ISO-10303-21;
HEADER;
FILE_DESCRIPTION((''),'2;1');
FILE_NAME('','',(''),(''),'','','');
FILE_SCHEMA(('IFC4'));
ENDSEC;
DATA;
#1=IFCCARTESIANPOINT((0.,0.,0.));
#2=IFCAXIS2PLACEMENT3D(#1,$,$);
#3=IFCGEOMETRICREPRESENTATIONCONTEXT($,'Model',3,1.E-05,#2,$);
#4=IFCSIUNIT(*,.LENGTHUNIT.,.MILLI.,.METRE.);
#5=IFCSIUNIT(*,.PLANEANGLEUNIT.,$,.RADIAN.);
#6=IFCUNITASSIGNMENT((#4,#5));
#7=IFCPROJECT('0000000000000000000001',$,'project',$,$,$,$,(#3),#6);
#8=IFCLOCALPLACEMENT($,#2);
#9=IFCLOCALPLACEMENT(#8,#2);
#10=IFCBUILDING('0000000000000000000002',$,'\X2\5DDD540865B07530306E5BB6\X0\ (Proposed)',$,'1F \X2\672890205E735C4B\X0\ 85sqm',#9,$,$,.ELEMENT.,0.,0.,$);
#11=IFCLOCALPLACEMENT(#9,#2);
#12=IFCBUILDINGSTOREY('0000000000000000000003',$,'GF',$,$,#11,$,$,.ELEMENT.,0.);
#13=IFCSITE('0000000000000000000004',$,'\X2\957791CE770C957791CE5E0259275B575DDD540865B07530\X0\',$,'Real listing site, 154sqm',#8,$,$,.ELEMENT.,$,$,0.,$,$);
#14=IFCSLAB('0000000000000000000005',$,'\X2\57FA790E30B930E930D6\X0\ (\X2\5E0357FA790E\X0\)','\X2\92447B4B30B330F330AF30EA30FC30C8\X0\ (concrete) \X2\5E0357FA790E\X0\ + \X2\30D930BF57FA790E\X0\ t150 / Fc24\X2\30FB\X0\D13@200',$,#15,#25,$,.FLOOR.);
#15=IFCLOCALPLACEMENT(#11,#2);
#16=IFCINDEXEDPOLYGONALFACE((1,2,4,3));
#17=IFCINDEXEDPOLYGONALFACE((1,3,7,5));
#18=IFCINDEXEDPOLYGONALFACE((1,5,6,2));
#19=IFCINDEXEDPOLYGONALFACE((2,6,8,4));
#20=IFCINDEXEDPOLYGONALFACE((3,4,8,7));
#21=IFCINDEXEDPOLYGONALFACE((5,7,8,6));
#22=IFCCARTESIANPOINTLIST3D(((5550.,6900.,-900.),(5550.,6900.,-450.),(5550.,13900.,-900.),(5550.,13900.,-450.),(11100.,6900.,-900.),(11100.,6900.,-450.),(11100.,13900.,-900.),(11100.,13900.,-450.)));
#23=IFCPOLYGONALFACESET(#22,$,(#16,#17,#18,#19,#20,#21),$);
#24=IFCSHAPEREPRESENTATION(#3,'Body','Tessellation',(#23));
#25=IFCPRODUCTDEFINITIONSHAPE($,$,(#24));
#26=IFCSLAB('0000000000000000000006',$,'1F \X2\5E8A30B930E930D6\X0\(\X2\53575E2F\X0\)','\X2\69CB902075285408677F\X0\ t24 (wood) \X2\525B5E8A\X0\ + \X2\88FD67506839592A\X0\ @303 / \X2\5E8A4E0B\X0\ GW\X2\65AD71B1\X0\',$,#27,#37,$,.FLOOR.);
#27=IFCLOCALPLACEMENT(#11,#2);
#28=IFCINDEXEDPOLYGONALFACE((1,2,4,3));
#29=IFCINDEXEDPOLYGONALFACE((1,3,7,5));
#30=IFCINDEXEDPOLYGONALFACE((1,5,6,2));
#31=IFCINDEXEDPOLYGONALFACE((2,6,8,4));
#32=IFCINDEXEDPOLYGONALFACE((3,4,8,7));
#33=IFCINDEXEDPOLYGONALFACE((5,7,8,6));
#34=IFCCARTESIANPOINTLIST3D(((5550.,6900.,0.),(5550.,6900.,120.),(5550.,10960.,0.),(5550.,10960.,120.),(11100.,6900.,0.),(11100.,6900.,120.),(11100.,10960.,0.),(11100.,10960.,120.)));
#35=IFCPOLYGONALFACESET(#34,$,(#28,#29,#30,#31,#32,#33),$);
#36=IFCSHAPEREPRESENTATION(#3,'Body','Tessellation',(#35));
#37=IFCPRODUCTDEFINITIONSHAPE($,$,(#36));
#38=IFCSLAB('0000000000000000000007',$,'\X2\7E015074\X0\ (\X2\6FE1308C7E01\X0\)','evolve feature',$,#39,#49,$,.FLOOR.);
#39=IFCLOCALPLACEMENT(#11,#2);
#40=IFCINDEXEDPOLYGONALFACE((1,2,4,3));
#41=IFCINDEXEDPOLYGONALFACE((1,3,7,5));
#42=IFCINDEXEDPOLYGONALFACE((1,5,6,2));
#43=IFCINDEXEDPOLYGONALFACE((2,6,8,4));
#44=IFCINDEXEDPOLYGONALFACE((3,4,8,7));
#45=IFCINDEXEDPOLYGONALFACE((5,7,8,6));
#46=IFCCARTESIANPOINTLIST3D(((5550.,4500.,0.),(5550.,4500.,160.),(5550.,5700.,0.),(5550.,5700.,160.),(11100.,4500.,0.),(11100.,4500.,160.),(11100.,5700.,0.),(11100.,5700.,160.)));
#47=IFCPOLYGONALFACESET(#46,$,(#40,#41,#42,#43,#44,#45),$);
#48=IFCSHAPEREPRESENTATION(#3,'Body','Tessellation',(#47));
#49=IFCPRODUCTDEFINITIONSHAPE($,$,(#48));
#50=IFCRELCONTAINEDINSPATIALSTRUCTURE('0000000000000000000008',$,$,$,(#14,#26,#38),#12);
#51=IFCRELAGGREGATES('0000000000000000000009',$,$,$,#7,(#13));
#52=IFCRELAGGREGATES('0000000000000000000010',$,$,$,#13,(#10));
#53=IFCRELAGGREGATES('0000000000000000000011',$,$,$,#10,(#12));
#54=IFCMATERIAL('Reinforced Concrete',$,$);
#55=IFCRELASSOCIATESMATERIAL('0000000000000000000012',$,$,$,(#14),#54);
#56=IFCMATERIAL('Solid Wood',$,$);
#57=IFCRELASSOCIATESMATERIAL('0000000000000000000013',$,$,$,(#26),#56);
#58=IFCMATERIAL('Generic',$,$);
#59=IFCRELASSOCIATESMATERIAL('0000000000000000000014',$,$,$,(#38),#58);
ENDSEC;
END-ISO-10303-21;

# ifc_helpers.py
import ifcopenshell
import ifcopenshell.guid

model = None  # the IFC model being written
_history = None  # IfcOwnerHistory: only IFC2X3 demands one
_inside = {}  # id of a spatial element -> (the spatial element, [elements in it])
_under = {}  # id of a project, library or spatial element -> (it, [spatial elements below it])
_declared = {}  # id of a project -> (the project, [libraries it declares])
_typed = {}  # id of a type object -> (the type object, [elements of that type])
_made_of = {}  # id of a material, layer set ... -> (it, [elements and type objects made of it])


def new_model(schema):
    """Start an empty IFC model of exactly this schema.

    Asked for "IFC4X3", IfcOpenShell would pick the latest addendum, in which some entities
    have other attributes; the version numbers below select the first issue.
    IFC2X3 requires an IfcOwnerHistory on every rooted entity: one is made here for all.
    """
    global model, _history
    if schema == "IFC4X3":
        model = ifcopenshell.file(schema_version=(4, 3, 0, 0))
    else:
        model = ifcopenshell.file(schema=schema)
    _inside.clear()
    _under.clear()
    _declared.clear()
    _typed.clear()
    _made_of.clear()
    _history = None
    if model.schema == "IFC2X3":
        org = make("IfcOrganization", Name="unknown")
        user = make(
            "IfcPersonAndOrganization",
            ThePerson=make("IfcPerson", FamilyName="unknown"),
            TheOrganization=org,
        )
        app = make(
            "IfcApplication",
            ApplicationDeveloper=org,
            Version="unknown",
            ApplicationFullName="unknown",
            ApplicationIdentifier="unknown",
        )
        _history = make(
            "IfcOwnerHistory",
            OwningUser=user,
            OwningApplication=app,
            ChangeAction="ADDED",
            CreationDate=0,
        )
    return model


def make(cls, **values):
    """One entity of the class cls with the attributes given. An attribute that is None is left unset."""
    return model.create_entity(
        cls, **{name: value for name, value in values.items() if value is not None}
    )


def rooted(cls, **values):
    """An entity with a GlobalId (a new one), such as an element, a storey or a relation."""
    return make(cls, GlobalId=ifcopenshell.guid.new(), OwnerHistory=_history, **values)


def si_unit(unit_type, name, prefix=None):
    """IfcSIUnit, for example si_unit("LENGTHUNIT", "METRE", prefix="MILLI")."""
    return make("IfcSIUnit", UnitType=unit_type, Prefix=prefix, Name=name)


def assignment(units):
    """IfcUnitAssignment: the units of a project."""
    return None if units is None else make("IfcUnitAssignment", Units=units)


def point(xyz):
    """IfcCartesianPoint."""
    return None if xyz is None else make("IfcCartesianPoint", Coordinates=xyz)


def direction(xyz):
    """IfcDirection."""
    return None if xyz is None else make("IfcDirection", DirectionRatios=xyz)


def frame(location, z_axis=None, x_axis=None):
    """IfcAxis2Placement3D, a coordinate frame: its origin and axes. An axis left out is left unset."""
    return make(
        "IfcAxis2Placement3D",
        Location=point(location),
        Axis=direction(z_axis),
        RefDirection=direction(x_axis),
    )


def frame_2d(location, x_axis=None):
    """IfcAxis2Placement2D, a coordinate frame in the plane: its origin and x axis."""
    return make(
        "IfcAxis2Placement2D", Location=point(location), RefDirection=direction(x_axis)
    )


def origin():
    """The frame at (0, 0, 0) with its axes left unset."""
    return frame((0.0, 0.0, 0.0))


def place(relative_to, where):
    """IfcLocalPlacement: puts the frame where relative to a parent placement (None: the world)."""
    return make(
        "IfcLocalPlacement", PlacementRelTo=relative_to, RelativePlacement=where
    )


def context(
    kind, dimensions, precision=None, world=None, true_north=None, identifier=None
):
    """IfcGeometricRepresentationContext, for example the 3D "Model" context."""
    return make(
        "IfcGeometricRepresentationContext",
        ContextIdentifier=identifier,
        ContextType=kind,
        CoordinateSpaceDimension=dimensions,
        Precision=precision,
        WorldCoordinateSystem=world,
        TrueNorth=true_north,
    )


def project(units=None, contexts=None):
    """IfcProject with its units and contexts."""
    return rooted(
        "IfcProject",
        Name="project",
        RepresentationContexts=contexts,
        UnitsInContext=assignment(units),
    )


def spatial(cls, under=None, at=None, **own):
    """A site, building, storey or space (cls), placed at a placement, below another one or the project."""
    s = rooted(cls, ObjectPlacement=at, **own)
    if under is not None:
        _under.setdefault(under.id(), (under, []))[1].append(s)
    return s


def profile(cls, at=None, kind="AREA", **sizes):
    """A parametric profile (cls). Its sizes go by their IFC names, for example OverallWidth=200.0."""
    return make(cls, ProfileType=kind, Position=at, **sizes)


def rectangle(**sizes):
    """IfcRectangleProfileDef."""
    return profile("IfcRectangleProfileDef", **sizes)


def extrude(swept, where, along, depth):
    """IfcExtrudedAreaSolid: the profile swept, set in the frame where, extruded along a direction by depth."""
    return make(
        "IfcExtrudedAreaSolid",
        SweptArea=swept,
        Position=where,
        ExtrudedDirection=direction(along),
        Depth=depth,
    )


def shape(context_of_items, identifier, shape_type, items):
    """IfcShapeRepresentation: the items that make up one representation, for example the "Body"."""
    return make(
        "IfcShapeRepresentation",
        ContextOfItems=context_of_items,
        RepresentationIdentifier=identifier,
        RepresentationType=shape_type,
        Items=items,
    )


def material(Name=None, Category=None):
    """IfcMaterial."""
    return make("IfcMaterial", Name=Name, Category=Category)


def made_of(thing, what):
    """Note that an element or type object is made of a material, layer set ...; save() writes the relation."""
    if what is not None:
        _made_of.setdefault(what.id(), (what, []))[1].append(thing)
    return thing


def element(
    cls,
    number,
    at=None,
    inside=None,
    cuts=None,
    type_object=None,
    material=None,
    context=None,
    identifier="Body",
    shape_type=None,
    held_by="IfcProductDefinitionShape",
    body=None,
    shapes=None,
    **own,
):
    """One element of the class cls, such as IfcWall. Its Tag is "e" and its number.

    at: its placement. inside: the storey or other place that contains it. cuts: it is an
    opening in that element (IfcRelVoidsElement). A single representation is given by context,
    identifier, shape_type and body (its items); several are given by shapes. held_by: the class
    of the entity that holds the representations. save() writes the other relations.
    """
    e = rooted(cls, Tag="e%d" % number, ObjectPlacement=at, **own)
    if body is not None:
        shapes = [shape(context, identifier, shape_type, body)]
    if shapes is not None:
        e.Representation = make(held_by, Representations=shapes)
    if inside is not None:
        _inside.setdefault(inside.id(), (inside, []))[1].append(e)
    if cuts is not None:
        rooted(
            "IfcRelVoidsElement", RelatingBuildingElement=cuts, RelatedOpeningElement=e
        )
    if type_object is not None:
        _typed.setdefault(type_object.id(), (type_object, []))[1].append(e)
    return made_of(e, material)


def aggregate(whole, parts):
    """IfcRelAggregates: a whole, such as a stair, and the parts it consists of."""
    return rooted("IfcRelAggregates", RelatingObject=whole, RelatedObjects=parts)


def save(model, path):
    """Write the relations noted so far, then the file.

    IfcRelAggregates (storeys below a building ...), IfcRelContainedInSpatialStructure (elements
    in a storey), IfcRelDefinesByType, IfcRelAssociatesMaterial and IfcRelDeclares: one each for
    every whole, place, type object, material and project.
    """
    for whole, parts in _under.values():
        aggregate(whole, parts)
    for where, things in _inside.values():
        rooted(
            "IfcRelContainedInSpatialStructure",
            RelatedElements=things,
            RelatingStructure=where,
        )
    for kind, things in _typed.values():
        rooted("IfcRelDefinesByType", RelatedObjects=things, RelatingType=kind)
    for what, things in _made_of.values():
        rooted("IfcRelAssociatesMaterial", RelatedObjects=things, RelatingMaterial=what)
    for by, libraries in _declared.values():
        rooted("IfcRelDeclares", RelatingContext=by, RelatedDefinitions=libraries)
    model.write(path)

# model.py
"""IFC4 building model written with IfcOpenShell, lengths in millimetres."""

from ifc_helpers import new_model, si_unit, frame, frame_2d, origin, place, context, project, spatial, rectangle, extrude, material, element, save


model = new_model("IFC4")

# Units and contexts
model_context = context("Model", 3, precision=1e-05, world=origin())
ifc_project = project(units=[si_unit("LENGTHUNIT", "METRE", prefix="MILLI"), si_unit("PLANEANGLEUNIT", "RADIAN")], contexts=[model_context])

# Site, building, storey
site_placement = place(None, origin())
site = spatial("IfcSite", under=ifc_project, at=site_placement, Name="長野県長野市大字川合新田", ObjectType="Real listing site, 154sqm", CompositionType="ELEMENT", RefElevation=0.0)
building_placement = place(site_placement, origin())
building = spatial("IfcBuilding", under=site, at=building_placement, Name="川合新田の家 (Proposed)", ObjectType="1F 木造平屋 85sqm", CompositionType="ELEMENT", ElevationOfRefHeight=0.0, ElevationOfTerrain=0.0)
storey_placement = place(building_placement, origin())
storey = spatial("IfcBuildingStorey", under=building, at=storey_placement, Name="GF", CompositionType="ELEMENT", Elevation=0.0)

# Slabs
ifc_material_1 = material(Name="Reinforced Concrete")
slab_1_placement = place(storey_placement, frame((2775.0, 3450.0, -450.0)))
element("IfcSlab", 1, at=slab_1_placement, inside=storey, material=ifc_material_1, Name="基礎スラブ (布基礎)", Description="鉄筋コンクリート (concrete) 布基礎 + ベタ基礎 t150 / Fc24・D13@200", PredefinedType="FLOOR", context=model_context, shape_type="SweptSolid", body=[
    extrude(rectangle(XDim=5550.0, YDim=7000.0, at=frame_2d((2775.0, 3500.0))), frame((2775.0, 3450.0, -450.0)), (0.0, 0.0, 1.0), 450.0),
])
ifc_material_2 = material(Name="Solid Wood")
slab_2_placement = place(storey_placement, frame((2775.0, 3450.0, 0.0)))
element("IfcSlab", 2, at=slab_2_placement, inside=storey, material=ifc_material_2, Name="1F 床スラブ(南帯)", Description="構造用合板 t24 (wood) 剛床 + 製材根太 @303 / 床下 GW断熱", PredefinedType="FLOOR", context=model_context, shape_type="SweptSolid", body=[
    extrude(rectangle(XDim=5550.0, YDim=4060.0, at=frame_2d((2775.0, 2030.0))), frame((2775.0, 3450.0, 0.0)), (0.0, 0.0, 1.0), 120.0),
])
ifc_material_3 = material(Name="Generic")
slab_3_placement = place(storey_placement, frame((2775.0, 2250.0, 0.0)))
element("IfcSlab", 3, at=slab_3_placement, inside=storey, material=ifc_material_3, Name="縁側 (濡れ縁)", Description="evolve feature", PredefinedType="FLOOR", context=model_context, shape_type="SweptSolid", body=[
    extrude(rectangle(XDim=5550.0, YDim=1200.0, at=frame_2d((2775.0, 600.0))), frame((2775.0, 2250.0, 0.0)), (0.0, 0.0, 1.0), 160.0),
])

save(model, "model.ifc")
